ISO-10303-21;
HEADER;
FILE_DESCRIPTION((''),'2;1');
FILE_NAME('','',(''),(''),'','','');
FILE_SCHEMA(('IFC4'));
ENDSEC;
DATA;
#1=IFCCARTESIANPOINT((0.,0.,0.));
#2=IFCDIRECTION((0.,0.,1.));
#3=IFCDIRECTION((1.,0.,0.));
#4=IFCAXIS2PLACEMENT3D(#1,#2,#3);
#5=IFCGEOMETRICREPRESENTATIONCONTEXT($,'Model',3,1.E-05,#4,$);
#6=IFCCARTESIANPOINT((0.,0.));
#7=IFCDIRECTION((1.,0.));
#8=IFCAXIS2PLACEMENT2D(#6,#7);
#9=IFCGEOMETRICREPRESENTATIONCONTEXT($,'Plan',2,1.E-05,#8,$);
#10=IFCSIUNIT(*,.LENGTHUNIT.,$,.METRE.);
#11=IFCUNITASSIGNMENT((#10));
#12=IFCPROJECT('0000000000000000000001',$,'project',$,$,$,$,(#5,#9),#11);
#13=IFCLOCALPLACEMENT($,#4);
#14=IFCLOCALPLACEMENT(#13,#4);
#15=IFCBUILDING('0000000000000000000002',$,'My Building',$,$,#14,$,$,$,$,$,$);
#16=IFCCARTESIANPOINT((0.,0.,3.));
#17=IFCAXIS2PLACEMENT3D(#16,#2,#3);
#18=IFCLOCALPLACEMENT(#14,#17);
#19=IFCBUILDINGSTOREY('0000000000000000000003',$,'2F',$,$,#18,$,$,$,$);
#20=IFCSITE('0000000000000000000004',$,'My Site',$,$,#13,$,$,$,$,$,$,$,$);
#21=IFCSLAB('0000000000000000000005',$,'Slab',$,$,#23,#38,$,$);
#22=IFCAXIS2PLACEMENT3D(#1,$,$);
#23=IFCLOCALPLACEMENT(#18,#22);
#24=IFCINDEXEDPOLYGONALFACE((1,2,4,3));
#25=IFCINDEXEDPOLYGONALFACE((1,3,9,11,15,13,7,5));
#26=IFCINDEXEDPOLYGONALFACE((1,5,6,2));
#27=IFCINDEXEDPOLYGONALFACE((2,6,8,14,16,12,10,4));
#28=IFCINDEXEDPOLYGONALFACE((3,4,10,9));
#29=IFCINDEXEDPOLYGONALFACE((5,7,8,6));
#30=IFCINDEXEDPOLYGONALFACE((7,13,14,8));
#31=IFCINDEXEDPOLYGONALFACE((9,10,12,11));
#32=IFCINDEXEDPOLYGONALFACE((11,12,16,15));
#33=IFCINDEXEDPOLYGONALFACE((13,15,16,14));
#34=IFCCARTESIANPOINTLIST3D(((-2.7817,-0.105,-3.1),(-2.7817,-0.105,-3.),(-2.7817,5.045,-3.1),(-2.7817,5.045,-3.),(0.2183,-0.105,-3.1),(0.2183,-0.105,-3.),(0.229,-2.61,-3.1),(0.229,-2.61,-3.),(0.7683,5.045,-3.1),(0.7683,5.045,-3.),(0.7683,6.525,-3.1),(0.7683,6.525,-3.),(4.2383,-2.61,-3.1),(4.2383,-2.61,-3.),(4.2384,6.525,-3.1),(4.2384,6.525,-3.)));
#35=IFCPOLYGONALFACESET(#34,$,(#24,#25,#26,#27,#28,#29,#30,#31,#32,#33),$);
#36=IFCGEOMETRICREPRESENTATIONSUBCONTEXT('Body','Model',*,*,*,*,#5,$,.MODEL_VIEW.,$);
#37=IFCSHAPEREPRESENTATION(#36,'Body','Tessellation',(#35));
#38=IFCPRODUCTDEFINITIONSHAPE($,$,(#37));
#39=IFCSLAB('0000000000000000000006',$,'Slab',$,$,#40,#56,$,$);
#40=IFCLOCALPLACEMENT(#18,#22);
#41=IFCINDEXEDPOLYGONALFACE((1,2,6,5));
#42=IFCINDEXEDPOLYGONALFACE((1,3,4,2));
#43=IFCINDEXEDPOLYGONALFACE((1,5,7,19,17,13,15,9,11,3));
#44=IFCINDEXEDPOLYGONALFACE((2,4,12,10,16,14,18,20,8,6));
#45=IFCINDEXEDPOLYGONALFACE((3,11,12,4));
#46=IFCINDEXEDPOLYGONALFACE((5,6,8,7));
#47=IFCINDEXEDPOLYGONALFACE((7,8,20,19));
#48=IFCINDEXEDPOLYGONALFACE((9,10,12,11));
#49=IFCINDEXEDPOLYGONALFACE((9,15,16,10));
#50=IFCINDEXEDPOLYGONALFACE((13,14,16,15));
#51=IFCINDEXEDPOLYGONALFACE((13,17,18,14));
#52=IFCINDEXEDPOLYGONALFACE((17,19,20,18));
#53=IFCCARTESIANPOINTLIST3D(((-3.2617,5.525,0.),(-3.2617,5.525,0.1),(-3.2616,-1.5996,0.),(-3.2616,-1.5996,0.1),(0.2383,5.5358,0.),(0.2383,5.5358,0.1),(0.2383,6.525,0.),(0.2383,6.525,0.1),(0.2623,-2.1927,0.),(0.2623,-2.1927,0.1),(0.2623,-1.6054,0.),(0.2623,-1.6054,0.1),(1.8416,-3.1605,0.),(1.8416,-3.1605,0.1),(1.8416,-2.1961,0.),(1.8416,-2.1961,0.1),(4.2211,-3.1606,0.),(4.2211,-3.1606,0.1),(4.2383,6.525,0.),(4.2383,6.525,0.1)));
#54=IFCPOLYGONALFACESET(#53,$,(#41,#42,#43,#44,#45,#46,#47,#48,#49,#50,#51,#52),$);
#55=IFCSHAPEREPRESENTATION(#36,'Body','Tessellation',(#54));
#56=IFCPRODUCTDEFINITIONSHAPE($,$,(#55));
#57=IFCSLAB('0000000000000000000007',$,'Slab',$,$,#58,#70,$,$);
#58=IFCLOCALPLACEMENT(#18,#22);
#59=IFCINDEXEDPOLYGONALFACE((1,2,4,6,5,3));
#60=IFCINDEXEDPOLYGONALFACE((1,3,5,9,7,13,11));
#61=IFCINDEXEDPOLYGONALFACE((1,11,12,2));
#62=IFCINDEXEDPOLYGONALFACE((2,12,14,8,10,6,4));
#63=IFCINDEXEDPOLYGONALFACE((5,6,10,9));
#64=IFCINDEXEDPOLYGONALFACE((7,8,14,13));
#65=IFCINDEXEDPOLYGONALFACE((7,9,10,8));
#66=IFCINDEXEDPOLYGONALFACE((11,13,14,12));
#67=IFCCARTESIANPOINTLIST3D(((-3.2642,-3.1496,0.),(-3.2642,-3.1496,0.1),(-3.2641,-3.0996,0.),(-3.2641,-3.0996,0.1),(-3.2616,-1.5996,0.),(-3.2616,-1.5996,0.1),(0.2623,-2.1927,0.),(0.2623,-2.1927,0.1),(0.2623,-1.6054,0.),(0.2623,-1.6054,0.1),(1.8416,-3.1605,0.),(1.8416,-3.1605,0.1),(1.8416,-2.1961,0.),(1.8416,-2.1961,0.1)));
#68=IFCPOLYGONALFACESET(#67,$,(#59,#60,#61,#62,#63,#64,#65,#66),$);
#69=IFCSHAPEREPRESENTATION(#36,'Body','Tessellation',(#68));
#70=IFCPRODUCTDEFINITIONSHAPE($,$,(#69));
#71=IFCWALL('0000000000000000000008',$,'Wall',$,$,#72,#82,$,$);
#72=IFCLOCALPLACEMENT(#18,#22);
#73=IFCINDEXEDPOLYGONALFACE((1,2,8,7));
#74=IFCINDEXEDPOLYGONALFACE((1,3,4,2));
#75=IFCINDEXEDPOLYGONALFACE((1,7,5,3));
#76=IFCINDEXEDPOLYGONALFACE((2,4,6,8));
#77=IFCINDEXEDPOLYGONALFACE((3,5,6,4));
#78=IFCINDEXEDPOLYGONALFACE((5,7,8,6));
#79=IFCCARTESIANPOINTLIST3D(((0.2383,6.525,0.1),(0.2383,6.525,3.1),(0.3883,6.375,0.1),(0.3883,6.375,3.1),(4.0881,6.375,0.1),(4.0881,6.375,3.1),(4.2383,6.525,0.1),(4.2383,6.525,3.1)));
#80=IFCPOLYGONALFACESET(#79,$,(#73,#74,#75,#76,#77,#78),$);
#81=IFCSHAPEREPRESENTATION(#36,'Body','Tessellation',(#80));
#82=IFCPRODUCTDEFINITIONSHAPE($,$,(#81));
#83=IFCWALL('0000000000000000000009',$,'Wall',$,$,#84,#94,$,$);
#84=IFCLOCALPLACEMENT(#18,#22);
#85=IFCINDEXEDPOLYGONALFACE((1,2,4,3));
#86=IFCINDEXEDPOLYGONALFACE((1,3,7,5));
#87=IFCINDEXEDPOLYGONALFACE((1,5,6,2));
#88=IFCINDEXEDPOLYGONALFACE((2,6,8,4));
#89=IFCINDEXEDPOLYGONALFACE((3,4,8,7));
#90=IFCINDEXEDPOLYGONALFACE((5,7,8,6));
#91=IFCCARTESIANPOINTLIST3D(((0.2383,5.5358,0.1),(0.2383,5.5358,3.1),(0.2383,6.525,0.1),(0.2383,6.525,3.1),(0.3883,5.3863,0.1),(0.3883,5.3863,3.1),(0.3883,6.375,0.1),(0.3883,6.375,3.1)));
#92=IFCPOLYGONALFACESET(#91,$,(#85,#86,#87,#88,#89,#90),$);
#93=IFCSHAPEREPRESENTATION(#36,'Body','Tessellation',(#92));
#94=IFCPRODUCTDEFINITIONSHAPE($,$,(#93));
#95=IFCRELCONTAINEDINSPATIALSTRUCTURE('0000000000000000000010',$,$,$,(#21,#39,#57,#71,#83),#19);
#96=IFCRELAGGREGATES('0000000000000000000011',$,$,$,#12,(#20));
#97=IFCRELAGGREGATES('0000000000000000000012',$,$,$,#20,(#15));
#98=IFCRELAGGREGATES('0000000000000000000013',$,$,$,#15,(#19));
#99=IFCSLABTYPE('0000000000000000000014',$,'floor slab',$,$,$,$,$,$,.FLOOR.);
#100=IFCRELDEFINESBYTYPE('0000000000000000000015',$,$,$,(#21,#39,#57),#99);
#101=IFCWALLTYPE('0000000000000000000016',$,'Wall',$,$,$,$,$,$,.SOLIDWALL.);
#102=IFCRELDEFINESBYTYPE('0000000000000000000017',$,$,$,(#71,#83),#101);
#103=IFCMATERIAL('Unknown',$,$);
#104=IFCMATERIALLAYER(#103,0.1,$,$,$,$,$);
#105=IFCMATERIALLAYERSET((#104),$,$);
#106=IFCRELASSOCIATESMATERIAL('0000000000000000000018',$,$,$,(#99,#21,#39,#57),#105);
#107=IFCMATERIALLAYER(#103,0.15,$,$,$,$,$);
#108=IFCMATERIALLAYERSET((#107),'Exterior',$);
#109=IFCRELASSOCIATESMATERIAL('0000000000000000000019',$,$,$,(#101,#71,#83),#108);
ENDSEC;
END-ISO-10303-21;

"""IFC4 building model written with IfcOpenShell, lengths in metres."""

from ifc_helpers import new_model, si_unit, frame, origin_with_axes, origin_2d_with_axis, place, context, subcontext, project, spatial, line, indexed_curve, outline, extrude, material, layer, layer_set, layer_usage, type_object, element, save


model = new_model("IFC4")

# Units and contexts
model_context = context("Model", 3, precision=1e-05, world=origin_with_axes())
plan_context = context("Plan", 2, precision=1e-05, world=origin_2d_with_axis())
body_context_1 = subcontext(model_context, "Body", "Model", "MODEL_VIEW")
ifc_project = project(units=[si_unit("LENGTHUNIT", "METRE")], contexts=[model_context, plan_context])

# Site, building, storey
site_placement = place(None, origin_with_axes())
site = spatial("IfcSite", under=ifc_project, at=site_placement, Name="My Site")
building_placement = place(site_placement, origin_with_axes())
building = spatial("IfcBuilding", under=site, at=building_placement, Name="My Building")
storey_placement = place(building_placement, frame((0.0, 0.0, 3.0), z_axis=(0.0, 0.0, 1.0), x_axis=(1.0, 0.0, 0.0)))
storey = spatial("IfcBuildingStorey", under=building, at=storey_placement, Name="2F")

# Slabs
ifc_material = material(Name="Unknown")
ifc_layer_1 = layer(ifc_material, 0.1)
ifc_layer_set_1 = layer_set([ifc_layer_1])
ifc_layer_usage_1 = layer_usage(ifc_layer_set_1, "AXIS3", "POSITIVE", -0.1)
slab_type = type_object("IfcSlabType", Name="floor slab", PredefinedType="FLOOR", material=ifc_layer_set_1)
slab_1_placement = place(storey_placement, frame((4.2383, -2.61, -3.0), z_axis=(0.0, 0.0, 1.0), x_axis=(1.0, 0.0, 0.0)))
element("IfcSlab", 1, at=slab_1_placement, inside=storey, type_object=slab_type, material=ifc_layer_usage_1, Name="Slab", context=body_context_1, shape_type="SweptSolid", body=[
    extrude(outline(indexed_curve([(0.0, 0.0), (0.0, 9.135), (-3.47, 9.135), (-3.47, 7.655), (-7.02, 7.655), (-7.02, 2.505), (-4.02, 2.505), (-4.0094, 0.0), (0.0, 0.0)])), frame((0.0, 0.0, -0.1), z_axis=(0.0, 0.0, 1.0), x_axis=(1.0, 0.0, 0.0)), (0.0, 0.0, 1.0), 0.1),
])
ifc_layer_usage_2 = layer_usage(ifc_layer_set_1, "AXIS3", "POSITIVE", -0.1)
slab_2_placement = place(storey_placement, frame((4.2211, -3.1606, 0.1), z_axis=(0.0, 0.0, 1.0), x_axis=(1.0, 0.0, 0.0)))
element("IfcSlab", 2, at=slab_2_placement, inside=storey, type_object=slab_type, material=ifc_layer_usage_2, Name="Slab", context=body_context_1, shape_type="SweptSolid", body=[
    extrude(outline(indexed_curve([(0.0, 0.0), (0.0172, 9.6856), (-3.9827, 9.6856), (-3.9827, 8.6964), (-7.4827, 8.6856), (-7.4827, 1.5611), (-3.9588, 1.5553), (-3.9588, 0.9679), (-2.3795, 0.9645), (-2.3795, 0.0001), (0.0, 0.0)])), frame((0.0, 0.0, -0.1), z_axis=(0.0, 0.0, 1.0), x_axis=(1.0, 0.0, 0.0)), (0.0, 0.0, 1.0), 0.1),
])
ifc_layer_usage_3 = layer_usage(ifc_layer_set_1, "AXIS3", "POSITIVE", -0.1)
slab_3_placement = place(storey_placement, frame((1.8416, -3.1605, 0.1), z_axis=(0.0, 0.0, 1.0), x_axis=(1.0, 0.0, 0.0)))
element("IfcSlab", 3, at=slab_3_placement, inside=storey, type_object=slab_type, material=ifc_layer_usage_3, Name="Slab", context=body_context_1, shape_type="SweptSolid", body=[
    extrude(outline(indexed_curve([(0.0, 0.0), (0.0, 0.9644), (-1.5793, 0.9678), (-1.5793, 1.5551), (-5.1033, 1.5609), (-5.1057, 0.0609), (-5.1058, 0.0109), (0.0, 0.0)])), frame((0.0, 0.0, -0.1), z_axis=(0.0, 0.0, 1.0), x_axis=(1.0, 0.0, 0.0)), (0.0, 0.0, 1.0), 0.1),
])

# Walls
ifc_layer_2 = layer(ifc_material, 0.15)
ifc_layer_set_2 = layer_set([ifc_layer_2], Name="Exterior")
ifc_layer_usage_4 = layer_usage(ifc_layer_set_2, "AXIS2", "POSITIVE", 0.0)
wall_type_1 = type_object("IfcWallType", Name="Wall", PredefinedType="SOLIDWALL", material=ifc_layer_set_2)
wall_1_placement = place(storey_placement, frame((4.2383, 6.525, 0.1), z_axis=(0.0, 0.0, 1.0), x_axis=(-1.0, 0.0, 0.0)))
element("IfcWall", 4, at=wall_1_placement, inside=storey, type_object=wall_type_1, material=ifc_layer_usage_4, Name="Wall", context=body_context_1, shape_type="SweptSolid", body=[
    extrude(outline(indexed_curve([(0.0, 0.0), (0.1503, 0.15), (3.85, 0.15), (4.0, 0.0)], segments=[line(1, 2, 3, 4, 1)])), origin_with_axes(), (0.0, 0.0, 1.0), 3.0),
])
ifc_layer_usage_5 = layer_usage(ifc_layer_set_2, "AXIS2", "POSITIVE", 0.0)
wall_2_placement = place(storey_placement, frame((0.2383, 6.525, 0.1), z_axis=(0.0, 0.0, 1.0), x_axis=(0.0, -1.0, 0.0)))
element("IfcWall", 5, at=wall_2_placement, inside=storey, type_object=wall_type_1, material=ifc_layer_usage_5, Name="Wall", context=body_context_1, shape_type="SweptSolid", body=[
    extrude(outline(indexed_curve([(0.0, 0.0), (0.15, 0.15), (1.1387, 0.15), (0.9892, 0.0)], segments=[line(1, 2, 3, 4, 1)])), origin_with_axes(), (0.0, 0.0, 1.0), 3.0),
])

save(model, "model.ifc")
